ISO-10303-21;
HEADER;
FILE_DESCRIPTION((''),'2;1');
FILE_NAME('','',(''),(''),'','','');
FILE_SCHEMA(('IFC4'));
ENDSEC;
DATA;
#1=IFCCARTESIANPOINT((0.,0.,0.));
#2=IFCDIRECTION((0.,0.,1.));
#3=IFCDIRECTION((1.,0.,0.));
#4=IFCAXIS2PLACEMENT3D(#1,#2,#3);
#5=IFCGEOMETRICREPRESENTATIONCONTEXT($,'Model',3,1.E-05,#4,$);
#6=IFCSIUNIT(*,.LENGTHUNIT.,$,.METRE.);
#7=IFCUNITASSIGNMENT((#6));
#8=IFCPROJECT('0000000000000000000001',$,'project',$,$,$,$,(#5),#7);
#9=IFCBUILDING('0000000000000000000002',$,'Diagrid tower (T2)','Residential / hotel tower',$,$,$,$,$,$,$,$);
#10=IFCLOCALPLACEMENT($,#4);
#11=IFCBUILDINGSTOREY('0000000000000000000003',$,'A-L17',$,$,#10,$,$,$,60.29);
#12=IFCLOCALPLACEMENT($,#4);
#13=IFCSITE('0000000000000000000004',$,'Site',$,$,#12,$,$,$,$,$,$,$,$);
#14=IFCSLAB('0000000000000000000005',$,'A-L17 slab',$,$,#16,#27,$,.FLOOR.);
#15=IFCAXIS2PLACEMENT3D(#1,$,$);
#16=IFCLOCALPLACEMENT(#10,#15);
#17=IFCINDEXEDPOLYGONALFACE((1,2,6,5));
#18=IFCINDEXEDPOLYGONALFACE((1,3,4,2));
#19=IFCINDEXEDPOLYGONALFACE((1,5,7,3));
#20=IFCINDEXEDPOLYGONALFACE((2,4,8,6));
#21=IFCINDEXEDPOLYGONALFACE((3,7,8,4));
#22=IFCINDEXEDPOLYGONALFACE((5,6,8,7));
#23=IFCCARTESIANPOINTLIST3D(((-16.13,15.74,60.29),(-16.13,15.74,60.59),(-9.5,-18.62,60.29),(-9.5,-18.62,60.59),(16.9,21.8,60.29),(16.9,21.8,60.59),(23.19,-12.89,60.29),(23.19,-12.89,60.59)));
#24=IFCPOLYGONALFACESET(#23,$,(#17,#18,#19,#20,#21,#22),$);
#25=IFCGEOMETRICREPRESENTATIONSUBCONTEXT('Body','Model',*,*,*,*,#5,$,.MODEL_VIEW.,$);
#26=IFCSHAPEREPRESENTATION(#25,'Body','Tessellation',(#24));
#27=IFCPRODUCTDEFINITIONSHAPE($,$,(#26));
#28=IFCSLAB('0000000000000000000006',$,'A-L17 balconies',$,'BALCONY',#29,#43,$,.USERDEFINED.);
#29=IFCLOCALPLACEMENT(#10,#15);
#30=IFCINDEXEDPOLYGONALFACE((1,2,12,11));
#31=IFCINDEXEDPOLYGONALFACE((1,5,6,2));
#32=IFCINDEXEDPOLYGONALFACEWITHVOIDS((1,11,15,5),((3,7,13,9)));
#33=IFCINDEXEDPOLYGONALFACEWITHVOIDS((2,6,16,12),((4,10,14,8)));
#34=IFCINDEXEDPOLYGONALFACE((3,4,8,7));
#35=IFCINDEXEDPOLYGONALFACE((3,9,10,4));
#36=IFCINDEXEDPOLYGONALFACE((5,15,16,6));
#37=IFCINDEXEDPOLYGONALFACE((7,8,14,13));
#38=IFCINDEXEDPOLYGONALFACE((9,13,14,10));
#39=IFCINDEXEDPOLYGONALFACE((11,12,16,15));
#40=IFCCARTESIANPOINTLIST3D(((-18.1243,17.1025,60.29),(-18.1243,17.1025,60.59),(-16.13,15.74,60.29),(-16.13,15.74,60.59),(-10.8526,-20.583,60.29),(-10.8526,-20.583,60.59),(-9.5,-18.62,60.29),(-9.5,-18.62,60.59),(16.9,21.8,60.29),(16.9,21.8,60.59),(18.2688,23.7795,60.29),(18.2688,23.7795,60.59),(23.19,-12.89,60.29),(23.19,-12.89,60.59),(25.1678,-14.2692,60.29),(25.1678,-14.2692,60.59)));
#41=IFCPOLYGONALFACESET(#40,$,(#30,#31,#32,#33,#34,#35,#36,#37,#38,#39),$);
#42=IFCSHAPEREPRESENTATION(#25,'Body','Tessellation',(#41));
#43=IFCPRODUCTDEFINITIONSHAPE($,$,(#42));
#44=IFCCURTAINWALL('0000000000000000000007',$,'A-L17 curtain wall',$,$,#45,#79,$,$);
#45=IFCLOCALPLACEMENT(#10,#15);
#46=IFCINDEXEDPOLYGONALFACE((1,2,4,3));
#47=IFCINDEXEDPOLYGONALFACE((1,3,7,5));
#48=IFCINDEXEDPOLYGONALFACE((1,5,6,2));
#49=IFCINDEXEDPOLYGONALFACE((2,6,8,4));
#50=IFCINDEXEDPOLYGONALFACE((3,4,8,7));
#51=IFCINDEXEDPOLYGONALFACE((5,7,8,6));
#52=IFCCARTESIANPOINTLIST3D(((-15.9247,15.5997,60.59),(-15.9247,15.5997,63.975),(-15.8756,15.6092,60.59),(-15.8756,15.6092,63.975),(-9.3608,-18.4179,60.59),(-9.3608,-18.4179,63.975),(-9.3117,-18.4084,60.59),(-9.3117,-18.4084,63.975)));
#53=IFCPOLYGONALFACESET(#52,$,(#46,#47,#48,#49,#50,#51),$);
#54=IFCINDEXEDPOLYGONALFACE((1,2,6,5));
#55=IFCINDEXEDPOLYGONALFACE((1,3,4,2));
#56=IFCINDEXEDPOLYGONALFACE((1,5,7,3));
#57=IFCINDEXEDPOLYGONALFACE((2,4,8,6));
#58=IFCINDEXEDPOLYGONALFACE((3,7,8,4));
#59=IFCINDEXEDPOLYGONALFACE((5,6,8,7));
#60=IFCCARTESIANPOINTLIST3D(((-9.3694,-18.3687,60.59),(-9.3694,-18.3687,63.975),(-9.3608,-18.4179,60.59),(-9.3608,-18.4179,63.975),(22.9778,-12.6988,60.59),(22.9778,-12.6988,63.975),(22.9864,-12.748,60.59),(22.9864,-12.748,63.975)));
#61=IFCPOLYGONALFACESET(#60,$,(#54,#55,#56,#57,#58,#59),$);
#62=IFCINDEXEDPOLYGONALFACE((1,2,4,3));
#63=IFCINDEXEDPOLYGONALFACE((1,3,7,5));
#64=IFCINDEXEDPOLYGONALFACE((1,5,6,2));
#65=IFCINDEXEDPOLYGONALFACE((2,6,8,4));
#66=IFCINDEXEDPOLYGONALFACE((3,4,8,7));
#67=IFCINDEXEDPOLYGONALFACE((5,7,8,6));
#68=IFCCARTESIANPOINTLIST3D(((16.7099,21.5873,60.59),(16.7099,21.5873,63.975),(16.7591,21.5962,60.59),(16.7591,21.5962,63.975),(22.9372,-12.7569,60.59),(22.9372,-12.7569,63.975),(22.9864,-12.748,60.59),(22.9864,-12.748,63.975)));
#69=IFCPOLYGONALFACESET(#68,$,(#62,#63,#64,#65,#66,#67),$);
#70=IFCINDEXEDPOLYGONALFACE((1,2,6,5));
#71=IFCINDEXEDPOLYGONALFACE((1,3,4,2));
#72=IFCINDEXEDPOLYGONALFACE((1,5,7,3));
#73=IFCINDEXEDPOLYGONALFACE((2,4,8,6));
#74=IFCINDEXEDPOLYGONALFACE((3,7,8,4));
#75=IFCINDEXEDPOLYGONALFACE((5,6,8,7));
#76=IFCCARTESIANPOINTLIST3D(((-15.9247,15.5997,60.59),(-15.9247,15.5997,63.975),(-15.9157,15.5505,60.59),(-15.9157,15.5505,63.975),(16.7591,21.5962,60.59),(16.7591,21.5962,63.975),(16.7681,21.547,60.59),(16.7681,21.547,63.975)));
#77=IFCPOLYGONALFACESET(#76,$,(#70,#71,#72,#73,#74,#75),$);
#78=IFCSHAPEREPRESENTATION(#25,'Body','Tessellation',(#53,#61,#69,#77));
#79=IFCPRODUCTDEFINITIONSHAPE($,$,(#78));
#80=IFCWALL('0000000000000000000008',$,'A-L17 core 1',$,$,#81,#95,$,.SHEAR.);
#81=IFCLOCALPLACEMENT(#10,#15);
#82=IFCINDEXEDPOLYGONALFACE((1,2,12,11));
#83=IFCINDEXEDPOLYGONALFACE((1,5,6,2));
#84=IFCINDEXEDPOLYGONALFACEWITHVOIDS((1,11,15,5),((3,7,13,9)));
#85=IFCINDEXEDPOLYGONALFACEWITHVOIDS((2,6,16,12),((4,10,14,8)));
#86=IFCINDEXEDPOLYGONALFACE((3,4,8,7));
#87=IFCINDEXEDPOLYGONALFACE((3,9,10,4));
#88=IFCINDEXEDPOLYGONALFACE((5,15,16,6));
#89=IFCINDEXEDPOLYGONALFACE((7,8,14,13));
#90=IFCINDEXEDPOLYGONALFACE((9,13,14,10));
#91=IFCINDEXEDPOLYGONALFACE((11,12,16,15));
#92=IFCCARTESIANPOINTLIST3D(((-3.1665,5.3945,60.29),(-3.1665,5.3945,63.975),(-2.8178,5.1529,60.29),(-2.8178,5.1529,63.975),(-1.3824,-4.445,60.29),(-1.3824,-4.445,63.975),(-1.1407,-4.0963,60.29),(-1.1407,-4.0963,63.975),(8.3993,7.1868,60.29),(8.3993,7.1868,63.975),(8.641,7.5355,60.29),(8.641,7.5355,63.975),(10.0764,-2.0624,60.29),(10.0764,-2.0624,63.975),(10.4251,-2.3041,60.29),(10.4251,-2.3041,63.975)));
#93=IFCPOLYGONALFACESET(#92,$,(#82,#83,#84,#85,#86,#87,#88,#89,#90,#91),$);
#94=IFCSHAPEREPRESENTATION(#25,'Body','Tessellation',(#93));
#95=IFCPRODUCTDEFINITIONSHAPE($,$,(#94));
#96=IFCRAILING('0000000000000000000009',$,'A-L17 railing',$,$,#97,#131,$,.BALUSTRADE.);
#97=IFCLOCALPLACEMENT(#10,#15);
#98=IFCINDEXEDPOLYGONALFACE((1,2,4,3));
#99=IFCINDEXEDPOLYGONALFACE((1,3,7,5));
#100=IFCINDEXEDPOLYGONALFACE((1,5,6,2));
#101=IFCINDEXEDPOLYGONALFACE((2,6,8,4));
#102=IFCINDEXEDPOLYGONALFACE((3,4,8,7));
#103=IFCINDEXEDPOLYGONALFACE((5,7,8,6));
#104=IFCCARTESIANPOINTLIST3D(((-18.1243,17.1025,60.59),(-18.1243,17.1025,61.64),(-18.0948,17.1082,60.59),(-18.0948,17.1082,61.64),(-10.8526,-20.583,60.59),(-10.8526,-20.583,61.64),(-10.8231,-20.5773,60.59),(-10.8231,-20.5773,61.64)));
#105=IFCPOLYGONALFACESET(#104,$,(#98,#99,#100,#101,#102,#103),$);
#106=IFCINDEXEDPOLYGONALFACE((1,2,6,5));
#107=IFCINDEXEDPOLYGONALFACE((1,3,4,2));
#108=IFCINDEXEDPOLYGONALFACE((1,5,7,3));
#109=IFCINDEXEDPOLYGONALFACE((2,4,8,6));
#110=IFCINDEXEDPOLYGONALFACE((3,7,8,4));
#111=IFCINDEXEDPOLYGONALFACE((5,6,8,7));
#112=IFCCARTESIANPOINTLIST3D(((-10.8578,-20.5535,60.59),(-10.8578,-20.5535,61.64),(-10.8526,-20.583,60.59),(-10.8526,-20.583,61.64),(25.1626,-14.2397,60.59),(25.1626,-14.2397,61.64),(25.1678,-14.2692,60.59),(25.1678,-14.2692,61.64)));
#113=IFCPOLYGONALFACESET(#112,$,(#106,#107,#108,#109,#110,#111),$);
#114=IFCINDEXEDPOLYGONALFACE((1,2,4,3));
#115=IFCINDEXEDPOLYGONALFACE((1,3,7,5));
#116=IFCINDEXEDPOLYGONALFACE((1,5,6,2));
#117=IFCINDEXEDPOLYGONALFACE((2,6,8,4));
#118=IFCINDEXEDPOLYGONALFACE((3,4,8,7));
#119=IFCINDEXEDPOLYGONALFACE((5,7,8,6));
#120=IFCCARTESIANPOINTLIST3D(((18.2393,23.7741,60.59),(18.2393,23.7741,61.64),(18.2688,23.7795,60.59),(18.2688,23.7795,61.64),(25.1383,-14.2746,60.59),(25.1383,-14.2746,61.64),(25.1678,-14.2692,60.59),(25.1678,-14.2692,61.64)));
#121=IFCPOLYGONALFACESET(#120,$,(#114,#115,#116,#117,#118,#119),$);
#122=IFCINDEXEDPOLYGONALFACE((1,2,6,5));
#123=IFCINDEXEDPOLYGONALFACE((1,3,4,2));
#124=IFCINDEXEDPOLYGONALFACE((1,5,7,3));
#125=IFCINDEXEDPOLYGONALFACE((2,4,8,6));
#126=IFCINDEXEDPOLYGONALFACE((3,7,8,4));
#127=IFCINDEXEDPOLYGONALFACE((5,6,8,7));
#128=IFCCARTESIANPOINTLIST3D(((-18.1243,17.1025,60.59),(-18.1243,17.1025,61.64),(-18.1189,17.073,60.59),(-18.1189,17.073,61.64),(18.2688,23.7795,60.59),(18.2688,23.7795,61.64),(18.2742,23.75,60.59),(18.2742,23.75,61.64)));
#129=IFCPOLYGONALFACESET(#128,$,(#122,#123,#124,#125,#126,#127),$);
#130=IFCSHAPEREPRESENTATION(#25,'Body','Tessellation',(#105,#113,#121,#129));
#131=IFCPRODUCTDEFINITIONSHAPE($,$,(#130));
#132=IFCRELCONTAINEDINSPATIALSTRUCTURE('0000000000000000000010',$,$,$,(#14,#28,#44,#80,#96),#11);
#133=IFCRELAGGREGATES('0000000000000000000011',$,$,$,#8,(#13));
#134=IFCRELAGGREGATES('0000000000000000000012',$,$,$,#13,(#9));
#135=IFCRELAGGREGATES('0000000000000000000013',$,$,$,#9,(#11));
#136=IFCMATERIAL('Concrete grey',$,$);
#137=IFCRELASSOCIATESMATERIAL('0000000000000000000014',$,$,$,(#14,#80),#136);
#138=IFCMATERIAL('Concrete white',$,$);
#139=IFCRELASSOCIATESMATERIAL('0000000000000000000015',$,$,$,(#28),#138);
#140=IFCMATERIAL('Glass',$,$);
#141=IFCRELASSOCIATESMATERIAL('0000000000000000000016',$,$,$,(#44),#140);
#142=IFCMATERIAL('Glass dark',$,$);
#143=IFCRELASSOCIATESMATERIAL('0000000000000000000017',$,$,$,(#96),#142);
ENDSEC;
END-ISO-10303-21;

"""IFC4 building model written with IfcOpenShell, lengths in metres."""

from ifc_helpers import new_model, si_unit, frame, origin_with_axes, place, context, subcontext, project, spatial, polyline, outline, extrude, material, element, save


model = new_model("IFC4")

# Units and contexts
model_context = context("Model", 3, precision=1e-05, world=origin_with_axes())
body_context = subcontext(model_context, "Body", "Model", "MODEL_VIEW")
ifc_project = project(units=[si_unit("LENGTHUNIT", "METRE")], contexts=[model_context])

# Site, building, storey
site_placement = place(None, origin_with_axes())
site = spatial("IfcSite", under=ifc_project, at=site_placement, Name="Site")
building = spatial("IfcBuilding", under=site, Name="Diagrid tower (T2)", Description="Residential / hotel tower")
storey_placement = place(None, origin_with_axes())
storey = spatial("IfcBuildingStorey", under=building, at=storey_placement, Name="A-L17", Elevation=60.29)

# Slabs
ifc_material_1 = material(Name="Concrete grey")
slab_1_placement = place(storey_placement, origin_with_axes())
element("IfcSlab", 1, at=slab_1_placement, inside=storey, material=ifc_material_1, Name="A-L17 slab", PredefinedType="FLOOR", context=body_context, shape_type="SweptSolid", body=[
    extrude(outline(polyline([(-16.13, 15.74), (-9.5, -18.62), (23.19, -12.89), (16.9, 21.8), (-16.13, 15.74)])), frame((0.0, 0.0, 60.29), z_axis=(0.0, 0.0, 1.0), x_axis=(1.0, 0.0, 0.0)), (0.0, 0.0, 1.0), 0.3),
])
ifc_material_2 = material(Name="Concrete white")
slab_2_placement = place(storey_placement, origin_with_axes())
element("IfcSlab", 2, at=slab_2_placement, inside=storey, material=ifc_material_2, Name="A-L17 balconies", ObjectType="BALCONY", PredefinedType="USERDEFINED", context=body_context, shape_type="SweptSolid", body=[
    extrude(outline(polyline([(-18.1243, 17.1025), (-10.8526, -20.583), (25.1678, -14.2692), (18.2688, 23.7795), (-18.1243, 17.1025)]), holes=[polyline([(-16.13, 15.74), (-9.5, -18.62), (23.19, -12.89), (16.9, 21.8), (-16.13, 15.74)])]), frame((0.0, 0.0, 60.29), z_axis=(0.0, 0.0, 1.0), x_axis=(1.0, 0.0, 0.0)), (0.0, 0.0, 1.0), 0.3),
])

# Curtain wall
ifc_material_3 = material(Name="Glass")
curtain_wall_placement = place(storey_placement, origin_with_axes())
element("IfcCurtainWall", 3, at=curtain_wall_placement, inside=storey, material=ifc_material_3, Name="A-L17 curtain wall", context=body_context, shape_type="SweptSolid", body=[
    extrude(outline(polyline([(-15.9247, 15.5997), (-9.3608, -18.4179), (-9.3117, -18.4084), (-15.8756, 15.6092), (-15.9247, 15.5997)])), frame((0.0, 0.0, 60.59), z_axis=(0.0, 0.0, 1.0), x_axis=(1.0, 0.0, 0.0)), (0.0, 0.0, 1.0), 3.385),
    extrude(outline(polyline([(-9.3608, -18.4179), (22.9864, -12.748), (22.9778, -12.6988), (-9.3694, -18.3687), (-9.3608, -18.4179)])), frame((0.0, 0.0, 60.59), z_axis=(0.0, 0.0, 1.0), x_axis=(1.0, 0.0, 0.0)), (0.0, 0.0, 1.0), 3.385),
    extrude(outline(polyline([(22.9864, -12.748), (16.7591, 21.5962), (16.7099, 21.5873), (22.9372, -12.7569), (22.9864, -12.748)])), frame((0.0, 0.0, 60.59), z_axis=(0.0, 0.0, 1.0), x_axis=(1.0, 0.0, 0.0)), (0.0, 0.0, 1.0), 3.385),
    extrude(outline(polyline([(16.7591, 21.5962), (-15.9247, 15.5997), (-15.9157, 15.5505), (16.7681, 21.547), (16.7591, 21.5962)])), frame((0.0, 0.0, 60.59), z_axis=(0.0, 0.0, 1.0), x_axis=(1.0, 0.0, 0.0)), (0.0, 0.0, 1.0), 3.385),
])

# Wall
wall_placement = place(storey_placement, origin_with_axes())
element("IfcWall", 4, at=wall_placement, inside=storey, material=ifc_material_1, Name="A-L17 core 1", PredefinedType="SHEAR", context=body_context, shape_type="SweptSolid", body=[
    extrude(outline(polyline([(10.4251, -2.3041), (8.641, 7.5355), (-3.1665, 5.3945), (-1.3824, -4.445), (10.4251, -2.3041)]), holes=[polyline([(10.0764, -2.0624), (8.3993, 7.1868), (-2.8178, 5.1529), (-1.1407, -4.0963), (10.0764, -2.0624)])]), frame((0.0, 0.0, 60.29), z_axis=(0.0, 0.0, 1.0), x_axis=(1.0, 0.0, 0.0)), (0.0, 0.0, 1.0), 3.685),
])

# Railing
ifc_material_4 = material(Name="Glass dark")
railing_placement = place(storey_placement, origin_with_axes())
element("IfcRailing", 5, at=railing_placement, inside=storey, material=ifc_material_4, Name="A-L17 railing", PredefinedType="BALUSTRADE", context=body_context, shape_type="SweptSolid", body=[
    extrude(outline(polyline([(-18.1243, 17.1025), (-10.8526, -20.583), (-10.8231, -20.5773), (-18.0948, 17.1082), (-18.1243, 17.1025)])), frame((0.0, 0.0, 60.59), z_axis=(0.0, 0.0, 1.0), x_axis=(1.0, 0.0, 0.0)), (0.0, 0.0, 1.0), 1.05),
    extrude(outline(polyline([(-10.8526, -20.583), (25.1678, -14.2692), (25.1626, -14.2397), (-10.8578, -20.5535), (-10.8526, -20.583)])), frame((0.0, 0.0, 60.59), z_axis=(0.0, 0.0, 1.0), x_axis=(1.0, 0.0, 0.0)), (0.0, 0.0, 1.0), 1.05),
    extrude(outline(polyline([(25.1678, -14.2692), (18.2688, 23.7795), (18.2393, 23.7741), (25.1383, -14.2746), (25.1678, -14.2692)])), frame((0.0, 0.0, 60.59), z_axis=(0.0, 0.0, 1.0), x_axis=(1.0, 0.0, 0.0)), (0.0, 0.0, 1.0), 1.05),
    extrude(outline(polyline([(18.2688, 23.7795), (-18.1243, 17.1025), (-18.1189, 17.073), (18.2742, 23.75), (18.2688, 23.7795)])), frame((0.0, 0.0, 60.59), z_axis=(0.0, 0.0, 1.0), x_axis=(1.0, 0.0, 0.0)), (0.0, 0.0, 1.0), 1.05),
])

save(model, "model.ifc")
